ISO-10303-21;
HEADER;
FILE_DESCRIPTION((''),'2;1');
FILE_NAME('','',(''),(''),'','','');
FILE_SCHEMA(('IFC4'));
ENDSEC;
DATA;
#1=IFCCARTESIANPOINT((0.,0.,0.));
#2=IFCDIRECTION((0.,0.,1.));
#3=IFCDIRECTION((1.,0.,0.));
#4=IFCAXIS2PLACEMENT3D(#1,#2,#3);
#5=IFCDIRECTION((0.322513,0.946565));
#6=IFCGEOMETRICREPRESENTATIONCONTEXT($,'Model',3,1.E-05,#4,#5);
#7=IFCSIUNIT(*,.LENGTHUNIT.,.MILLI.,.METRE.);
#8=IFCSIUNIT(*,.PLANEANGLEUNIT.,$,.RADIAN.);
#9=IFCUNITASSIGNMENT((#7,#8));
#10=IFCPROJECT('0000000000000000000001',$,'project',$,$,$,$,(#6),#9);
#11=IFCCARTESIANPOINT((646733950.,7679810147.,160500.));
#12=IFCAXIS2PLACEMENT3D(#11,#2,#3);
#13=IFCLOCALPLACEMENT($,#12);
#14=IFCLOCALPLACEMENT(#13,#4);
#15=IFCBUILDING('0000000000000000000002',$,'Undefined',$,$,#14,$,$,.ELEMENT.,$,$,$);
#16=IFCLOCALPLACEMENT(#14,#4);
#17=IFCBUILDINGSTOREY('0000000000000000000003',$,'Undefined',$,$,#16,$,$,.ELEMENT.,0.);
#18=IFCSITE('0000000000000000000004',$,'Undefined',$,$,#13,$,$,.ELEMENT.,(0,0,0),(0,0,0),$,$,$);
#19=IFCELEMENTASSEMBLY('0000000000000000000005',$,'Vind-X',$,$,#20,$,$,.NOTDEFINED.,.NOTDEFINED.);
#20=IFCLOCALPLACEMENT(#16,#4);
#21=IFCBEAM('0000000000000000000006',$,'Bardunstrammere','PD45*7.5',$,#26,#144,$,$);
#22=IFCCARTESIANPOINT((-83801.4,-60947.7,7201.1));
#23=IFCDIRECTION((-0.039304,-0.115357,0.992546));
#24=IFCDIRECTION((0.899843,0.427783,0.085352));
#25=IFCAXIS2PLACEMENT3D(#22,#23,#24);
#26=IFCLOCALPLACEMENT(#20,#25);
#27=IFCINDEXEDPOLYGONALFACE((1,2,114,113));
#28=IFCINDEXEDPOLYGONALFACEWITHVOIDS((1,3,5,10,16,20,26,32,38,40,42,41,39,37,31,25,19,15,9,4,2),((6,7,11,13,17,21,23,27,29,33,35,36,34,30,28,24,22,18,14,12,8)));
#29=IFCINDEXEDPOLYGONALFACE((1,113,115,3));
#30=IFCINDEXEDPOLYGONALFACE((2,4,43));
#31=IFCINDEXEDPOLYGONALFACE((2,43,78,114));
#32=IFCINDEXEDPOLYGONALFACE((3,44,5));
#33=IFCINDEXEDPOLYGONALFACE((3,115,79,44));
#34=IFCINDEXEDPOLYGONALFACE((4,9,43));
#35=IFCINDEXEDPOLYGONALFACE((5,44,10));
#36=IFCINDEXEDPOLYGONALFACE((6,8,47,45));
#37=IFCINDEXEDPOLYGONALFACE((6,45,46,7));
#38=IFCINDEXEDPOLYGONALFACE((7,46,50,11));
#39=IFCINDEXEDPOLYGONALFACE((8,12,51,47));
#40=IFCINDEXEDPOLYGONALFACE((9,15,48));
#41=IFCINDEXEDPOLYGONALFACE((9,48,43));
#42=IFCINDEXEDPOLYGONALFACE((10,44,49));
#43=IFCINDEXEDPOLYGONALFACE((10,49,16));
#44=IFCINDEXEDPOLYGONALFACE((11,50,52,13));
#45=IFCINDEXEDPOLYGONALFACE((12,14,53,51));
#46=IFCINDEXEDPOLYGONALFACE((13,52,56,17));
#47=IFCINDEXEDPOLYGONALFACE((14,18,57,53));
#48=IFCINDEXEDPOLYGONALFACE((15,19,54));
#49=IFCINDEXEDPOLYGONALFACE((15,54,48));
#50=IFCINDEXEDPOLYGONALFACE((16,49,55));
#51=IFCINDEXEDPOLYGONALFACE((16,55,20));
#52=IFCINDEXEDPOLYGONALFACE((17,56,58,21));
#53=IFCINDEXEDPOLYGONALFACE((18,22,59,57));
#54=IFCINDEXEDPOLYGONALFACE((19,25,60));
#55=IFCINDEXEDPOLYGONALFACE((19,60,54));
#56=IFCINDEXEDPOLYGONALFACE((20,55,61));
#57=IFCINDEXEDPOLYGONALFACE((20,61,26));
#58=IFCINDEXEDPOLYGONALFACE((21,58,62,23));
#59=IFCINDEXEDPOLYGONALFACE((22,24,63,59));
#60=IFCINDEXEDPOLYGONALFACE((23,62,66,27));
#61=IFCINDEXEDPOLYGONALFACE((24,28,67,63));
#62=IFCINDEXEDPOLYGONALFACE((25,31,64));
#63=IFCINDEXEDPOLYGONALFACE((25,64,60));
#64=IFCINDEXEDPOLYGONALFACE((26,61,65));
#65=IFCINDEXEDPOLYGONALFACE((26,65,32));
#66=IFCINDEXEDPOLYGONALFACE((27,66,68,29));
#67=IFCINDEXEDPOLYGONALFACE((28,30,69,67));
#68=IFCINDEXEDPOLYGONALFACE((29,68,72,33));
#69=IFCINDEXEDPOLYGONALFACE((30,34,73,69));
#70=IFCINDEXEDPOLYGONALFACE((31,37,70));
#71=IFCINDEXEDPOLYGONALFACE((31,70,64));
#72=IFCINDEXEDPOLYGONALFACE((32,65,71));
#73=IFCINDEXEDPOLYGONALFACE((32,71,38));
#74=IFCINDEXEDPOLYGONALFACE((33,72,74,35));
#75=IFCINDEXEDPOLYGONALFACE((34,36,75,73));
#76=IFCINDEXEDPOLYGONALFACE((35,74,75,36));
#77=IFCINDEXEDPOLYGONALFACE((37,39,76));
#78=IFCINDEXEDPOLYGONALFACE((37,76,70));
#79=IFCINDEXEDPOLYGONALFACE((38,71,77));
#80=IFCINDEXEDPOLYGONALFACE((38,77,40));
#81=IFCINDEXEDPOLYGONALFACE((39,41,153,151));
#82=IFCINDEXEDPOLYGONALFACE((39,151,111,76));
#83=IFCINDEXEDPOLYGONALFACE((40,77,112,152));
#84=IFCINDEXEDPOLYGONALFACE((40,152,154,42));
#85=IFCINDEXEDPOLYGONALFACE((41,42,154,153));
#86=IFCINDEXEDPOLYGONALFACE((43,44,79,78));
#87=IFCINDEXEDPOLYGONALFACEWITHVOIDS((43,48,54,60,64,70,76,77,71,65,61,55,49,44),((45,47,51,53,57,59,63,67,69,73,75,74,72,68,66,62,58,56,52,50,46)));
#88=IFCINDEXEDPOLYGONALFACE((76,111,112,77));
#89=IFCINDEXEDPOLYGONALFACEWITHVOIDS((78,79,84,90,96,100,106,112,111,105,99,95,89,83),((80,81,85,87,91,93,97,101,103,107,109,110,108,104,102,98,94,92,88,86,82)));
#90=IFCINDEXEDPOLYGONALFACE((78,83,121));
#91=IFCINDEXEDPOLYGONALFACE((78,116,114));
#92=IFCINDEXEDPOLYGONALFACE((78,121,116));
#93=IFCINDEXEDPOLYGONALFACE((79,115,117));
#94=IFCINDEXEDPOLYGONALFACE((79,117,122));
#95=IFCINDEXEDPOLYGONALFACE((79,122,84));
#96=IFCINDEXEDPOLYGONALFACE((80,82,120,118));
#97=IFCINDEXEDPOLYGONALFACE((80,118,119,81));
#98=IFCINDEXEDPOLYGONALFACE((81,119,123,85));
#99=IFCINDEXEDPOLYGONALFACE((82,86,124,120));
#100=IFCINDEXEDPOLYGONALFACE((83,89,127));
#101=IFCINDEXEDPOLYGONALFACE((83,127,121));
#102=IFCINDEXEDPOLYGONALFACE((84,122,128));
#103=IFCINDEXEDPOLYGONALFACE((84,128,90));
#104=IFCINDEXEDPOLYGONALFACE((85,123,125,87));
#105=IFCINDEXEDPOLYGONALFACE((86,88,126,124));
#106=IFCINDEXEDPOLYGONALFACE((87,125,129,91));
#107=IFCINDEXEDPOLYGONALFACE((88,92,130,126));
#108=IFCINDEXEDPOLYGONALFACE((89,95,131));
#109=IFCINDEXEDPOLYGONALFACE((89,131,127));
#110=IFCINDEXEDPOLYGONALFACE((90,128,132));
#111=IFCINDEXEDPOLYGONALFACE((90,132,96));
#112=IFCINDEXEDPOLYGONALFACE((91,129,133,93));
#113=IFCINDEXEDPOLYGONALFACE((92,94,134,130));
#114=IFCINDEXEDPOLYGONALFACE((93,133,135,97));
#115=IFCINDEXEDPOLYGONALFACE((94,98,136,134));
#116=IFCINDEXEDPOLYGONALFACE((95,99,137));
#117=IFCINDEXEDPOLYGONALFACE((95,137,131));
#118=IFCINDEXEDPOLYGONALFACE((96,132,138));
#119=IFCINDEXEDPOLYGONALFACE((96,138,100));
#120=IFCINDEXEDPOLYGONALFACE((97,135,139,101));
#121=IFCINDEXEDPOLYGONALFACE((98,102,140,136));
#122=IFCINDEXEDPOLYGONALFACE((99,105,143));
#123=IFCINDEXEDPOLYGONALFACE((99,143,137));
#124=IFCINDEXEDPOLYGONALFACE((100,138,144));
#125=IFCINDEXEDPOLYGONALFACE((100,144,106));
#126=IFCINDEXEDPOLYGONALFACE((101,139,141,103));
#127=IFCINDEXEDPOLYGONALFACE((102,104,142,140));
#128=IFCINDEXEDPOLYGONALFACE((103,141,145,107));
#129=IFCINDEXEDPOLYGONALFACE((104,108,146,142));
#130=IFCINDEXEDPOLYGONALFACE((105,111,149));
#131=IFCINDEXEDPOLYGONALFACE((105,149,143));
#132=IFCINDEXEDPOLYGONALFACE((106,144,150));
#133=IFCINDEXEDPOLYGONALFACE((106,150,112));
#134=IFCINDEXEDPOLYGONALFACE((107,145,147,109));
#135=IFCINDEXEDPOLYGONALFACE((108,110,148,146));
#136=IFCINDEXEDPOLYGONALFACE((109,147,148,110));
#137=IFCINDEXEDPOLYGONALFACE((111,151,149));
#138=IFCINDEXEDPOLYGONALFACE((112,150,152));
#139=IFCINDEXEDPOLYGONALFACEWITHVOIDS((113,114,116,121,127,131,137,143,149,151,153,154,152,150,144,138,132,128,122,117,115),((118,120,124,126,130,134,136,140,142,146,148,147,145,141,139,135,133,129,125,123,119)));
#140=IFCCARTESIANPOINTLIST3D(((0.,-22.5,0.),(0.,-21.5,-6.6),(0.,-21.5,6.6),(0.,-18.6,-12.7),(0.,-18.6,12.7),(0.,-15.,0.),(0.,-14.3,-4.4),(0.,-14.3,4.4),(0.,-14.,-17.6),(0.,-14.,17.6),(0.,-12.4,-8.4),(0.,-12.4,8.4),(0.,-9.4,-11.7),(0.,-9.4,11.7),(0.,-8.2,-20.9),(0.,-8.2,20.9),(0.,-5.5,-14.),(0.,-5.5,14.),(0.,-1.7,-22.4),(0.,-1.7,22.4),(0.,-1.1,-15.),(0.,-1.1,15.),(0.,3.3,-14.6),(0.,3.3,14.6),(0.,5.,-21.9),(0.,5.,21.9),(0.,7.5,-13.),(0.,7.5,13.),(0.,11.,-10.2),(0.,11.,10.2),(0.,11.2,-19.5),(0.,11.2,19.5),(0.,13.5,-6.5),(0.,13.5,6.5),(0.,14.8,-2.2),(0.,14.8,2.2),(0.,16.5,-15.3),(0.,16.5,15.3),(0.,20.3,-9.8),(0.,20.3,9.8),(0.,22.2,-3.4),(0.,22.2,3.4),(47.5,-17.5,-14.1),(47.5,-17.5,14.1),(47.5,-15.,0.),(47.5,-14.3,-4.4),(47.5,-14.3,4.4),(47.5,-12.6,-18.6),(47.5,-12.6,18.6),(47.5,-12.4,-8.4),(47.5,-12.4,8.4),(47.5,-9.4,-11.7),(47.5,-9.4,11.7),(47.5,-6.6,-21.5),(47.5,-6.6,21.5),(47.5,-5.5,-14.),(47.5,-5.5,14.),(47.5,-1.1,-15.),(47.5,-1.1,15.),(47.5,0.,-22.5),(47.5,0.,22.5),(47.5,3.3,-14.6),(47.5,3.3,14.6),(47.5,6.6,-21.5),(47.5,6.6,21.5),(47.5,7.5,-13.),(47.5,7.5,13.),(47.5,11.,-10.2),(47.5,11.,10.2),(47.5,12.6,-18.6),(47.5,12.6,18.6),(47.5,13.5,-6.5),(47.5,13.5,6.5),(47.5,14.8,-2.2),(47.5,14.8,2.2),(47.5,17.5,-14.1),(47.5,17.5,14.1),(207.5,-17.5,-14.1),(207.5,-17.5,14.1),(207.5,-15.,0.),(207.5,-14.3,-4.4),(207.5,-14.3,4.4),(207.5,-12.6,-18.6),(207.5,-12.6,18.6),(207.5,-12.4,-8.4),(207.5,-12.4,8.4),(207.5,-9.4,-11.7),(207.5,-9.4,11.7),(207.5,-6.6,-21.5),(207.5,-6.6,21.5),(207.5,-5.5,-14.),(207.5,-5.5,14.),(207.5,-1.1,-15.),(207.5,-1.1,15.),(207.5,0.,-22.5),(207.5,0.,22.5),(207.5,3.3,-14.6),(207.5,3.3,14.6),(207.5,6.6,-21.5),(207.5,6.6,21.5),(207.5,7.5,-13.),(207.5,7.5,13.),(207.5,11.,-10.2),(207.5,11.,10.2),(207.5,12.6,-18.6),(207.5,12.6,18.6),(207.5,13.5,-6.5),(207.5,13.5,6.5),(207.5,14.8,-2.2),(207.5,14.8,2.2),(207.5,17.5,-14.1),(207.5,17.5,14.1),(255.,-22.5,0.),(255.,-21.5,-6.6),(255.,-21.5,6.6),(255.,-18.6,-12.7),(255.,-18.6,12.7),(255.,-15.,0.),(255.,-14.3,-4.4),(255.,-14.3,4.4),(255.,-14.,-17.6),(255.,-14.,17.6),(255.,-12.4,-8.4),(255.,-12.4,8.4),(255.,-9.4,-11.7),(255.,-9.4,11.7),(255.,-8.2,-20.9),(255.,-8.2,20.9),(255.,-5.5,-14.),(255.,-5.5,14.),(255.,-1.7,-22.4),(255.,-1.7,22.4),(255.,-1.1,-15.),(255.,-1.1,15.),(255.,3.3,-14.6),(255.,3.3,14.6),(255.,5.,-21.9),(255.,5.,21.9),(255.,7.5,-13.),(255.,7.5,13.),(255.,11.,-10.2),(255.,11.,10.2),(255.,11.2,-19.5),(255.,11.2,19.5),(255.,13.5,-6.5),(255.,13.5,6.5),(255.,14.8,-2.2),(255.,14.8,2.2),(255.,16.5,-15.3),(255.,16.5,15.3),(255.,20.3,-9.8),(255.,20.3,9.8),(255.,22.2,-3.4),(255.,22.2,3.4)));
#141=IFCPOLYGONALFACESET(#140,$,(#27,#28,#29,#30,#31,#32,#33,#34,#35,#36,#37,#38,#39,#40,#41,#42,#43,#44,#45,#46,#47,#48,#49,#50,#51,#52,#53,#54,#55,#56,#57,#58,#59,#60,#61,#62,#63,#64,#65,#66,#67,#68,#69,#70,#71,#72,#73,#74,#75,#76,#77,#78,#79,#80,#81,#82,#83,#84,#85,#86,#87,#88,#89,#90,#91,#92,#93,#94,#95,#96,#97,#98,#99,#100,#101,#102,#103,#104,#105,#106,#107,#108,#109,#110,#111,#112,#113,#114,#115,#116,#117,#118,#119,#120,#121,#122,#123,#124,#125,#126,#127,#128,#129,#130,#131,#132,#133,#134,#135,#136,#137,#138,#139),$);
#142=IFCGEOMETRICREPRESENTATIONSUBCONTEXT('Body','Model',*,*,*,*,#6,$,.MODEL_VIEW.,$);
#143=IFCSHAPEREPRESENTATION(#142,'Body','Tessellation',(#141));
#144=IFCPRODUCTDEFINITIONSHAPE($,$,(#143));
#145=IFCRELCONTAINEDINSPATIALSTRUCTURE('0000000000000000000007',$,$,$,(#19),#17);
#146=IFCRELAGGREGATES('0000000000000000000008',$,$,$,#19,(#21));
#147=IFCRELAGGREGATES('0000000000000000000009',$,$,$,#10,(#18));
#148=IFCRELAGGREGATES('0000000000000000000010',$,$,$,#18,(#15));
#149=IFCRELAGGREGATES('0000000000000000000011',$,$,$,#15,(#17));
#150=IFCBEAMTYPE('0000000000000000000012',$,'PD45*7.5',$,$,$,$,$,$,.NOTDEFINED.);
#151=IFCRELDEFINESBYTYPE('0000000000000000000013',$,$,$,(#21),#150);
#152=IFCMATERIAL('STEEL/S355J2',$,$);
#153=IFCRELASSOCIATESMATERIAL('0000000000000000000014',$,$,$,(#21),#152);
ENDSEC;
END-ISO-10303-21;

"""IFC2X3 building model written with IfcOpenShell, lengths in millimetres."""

from ifc_helpers import new_model, si_unit, direction, frame, origin_with_axes, origin_2d_with_axis, place, context, subcontext, project, spatial, rectangle, hollow_circle, extrude, boolean, material, type_object, element, aggregate, save


model = new_model("IFC2X3")

# Units and contexts
model_context = context("Model", 3, precision=1e-05, world=origin_with_axes(), true_north=direction((0.322513, 0.946565)))
body_context = subcontext(model_context, "Body", "Model", "MODEL_VIEW")
ifc_project = project(units=[si_unit("LENGTHUNIT", "METRE", prefix="MILLI"), si_unit("PLANEANGLEUNIT", "RADIAN")], contexts=[model_context])

# Site, building, storey
site_placement = place(None, frame((646733950.0, 7679810147.0, 160500.0), z_axis=(0.0, 0.0, 1.0), x_axis=(1.0, 0.0, 0.0)))
site = spatial("IfcSite", under=ifc_project, at=site_placement, Name="Undefined", CompositionType="ELEMENT", RefLatitude=(0, 0, 0), RefLongitude=(0, 0, 0))
building_placement = place(site_placement, origin_with_axes())
building = spatial("IfcBuilding", under=site, at=building_placement, Name="Undefined", CompositionType="ELEMENT")
storey_placement = place(building_placement, origin_with_axes())
storey = spatial("IfcBuildingStorey", under=building, at=storey_placement, Name="Undefined", CompositionType="ELEMENT", Elevation=0.0)

# Element assembly, beam
assembly_1_placement = place(storey_placement, origin_with_axes())
assembly_1 = element("IfcElementAssembly", 1, at=assembly_1_placement, inside=storey, Name="Vind-X", AssemblyPlace="NOTDEFINED", PredefinedType="NOTDEFINED")
ifc_material_1 = material(Name="STEEL/S355J2")
beam_type_1 = type_object("IfcBeamType", Name="PD45*7.5", PredefinedType="NOTDEFINED")
beam_1_placement = place(assembly_1_placement, frame((-83801.4, -60947.7, 7201.1), z_axis=(-0.039304, -0.115357, 0.992546), x_axis=(0.899843, 0.427783, 0.085352)))
beam_1 = element("IfcBeam", 2, at=beam_1_placement, type_object=beam_type_1, material=ifc_material_1, Name="Bardunstrammere", Description="PD45*7.5", context=body_context, shape_type="CSG", body=[
    boolean("DIFFERENCE", extrude(hollow_circle(Radius=22.5, WallThickness=7.5, at=origin_2d_with_axis()), frame((255.0, 0.0, 0.0), z_axis=(-1.0, 0.0, 0.0), x_axis=(0.0, -1.0, 0.0)), (0.0, 0.0, 1.0), 255.0), extrude(rectangle(XDim=35.0, YDim=90.0, at=origin_2d_with_axis()), frame((207.5, 0.0, 0.0), z_axis=(-1.0, 0.0, 0.0), x_axis=(0.0, -1.0, 0.0)), (0.0, 0.0, 1.0), 160.0)),
])

aggregate(assembly_1, [beam_1])

save(model, "model.ifc")
